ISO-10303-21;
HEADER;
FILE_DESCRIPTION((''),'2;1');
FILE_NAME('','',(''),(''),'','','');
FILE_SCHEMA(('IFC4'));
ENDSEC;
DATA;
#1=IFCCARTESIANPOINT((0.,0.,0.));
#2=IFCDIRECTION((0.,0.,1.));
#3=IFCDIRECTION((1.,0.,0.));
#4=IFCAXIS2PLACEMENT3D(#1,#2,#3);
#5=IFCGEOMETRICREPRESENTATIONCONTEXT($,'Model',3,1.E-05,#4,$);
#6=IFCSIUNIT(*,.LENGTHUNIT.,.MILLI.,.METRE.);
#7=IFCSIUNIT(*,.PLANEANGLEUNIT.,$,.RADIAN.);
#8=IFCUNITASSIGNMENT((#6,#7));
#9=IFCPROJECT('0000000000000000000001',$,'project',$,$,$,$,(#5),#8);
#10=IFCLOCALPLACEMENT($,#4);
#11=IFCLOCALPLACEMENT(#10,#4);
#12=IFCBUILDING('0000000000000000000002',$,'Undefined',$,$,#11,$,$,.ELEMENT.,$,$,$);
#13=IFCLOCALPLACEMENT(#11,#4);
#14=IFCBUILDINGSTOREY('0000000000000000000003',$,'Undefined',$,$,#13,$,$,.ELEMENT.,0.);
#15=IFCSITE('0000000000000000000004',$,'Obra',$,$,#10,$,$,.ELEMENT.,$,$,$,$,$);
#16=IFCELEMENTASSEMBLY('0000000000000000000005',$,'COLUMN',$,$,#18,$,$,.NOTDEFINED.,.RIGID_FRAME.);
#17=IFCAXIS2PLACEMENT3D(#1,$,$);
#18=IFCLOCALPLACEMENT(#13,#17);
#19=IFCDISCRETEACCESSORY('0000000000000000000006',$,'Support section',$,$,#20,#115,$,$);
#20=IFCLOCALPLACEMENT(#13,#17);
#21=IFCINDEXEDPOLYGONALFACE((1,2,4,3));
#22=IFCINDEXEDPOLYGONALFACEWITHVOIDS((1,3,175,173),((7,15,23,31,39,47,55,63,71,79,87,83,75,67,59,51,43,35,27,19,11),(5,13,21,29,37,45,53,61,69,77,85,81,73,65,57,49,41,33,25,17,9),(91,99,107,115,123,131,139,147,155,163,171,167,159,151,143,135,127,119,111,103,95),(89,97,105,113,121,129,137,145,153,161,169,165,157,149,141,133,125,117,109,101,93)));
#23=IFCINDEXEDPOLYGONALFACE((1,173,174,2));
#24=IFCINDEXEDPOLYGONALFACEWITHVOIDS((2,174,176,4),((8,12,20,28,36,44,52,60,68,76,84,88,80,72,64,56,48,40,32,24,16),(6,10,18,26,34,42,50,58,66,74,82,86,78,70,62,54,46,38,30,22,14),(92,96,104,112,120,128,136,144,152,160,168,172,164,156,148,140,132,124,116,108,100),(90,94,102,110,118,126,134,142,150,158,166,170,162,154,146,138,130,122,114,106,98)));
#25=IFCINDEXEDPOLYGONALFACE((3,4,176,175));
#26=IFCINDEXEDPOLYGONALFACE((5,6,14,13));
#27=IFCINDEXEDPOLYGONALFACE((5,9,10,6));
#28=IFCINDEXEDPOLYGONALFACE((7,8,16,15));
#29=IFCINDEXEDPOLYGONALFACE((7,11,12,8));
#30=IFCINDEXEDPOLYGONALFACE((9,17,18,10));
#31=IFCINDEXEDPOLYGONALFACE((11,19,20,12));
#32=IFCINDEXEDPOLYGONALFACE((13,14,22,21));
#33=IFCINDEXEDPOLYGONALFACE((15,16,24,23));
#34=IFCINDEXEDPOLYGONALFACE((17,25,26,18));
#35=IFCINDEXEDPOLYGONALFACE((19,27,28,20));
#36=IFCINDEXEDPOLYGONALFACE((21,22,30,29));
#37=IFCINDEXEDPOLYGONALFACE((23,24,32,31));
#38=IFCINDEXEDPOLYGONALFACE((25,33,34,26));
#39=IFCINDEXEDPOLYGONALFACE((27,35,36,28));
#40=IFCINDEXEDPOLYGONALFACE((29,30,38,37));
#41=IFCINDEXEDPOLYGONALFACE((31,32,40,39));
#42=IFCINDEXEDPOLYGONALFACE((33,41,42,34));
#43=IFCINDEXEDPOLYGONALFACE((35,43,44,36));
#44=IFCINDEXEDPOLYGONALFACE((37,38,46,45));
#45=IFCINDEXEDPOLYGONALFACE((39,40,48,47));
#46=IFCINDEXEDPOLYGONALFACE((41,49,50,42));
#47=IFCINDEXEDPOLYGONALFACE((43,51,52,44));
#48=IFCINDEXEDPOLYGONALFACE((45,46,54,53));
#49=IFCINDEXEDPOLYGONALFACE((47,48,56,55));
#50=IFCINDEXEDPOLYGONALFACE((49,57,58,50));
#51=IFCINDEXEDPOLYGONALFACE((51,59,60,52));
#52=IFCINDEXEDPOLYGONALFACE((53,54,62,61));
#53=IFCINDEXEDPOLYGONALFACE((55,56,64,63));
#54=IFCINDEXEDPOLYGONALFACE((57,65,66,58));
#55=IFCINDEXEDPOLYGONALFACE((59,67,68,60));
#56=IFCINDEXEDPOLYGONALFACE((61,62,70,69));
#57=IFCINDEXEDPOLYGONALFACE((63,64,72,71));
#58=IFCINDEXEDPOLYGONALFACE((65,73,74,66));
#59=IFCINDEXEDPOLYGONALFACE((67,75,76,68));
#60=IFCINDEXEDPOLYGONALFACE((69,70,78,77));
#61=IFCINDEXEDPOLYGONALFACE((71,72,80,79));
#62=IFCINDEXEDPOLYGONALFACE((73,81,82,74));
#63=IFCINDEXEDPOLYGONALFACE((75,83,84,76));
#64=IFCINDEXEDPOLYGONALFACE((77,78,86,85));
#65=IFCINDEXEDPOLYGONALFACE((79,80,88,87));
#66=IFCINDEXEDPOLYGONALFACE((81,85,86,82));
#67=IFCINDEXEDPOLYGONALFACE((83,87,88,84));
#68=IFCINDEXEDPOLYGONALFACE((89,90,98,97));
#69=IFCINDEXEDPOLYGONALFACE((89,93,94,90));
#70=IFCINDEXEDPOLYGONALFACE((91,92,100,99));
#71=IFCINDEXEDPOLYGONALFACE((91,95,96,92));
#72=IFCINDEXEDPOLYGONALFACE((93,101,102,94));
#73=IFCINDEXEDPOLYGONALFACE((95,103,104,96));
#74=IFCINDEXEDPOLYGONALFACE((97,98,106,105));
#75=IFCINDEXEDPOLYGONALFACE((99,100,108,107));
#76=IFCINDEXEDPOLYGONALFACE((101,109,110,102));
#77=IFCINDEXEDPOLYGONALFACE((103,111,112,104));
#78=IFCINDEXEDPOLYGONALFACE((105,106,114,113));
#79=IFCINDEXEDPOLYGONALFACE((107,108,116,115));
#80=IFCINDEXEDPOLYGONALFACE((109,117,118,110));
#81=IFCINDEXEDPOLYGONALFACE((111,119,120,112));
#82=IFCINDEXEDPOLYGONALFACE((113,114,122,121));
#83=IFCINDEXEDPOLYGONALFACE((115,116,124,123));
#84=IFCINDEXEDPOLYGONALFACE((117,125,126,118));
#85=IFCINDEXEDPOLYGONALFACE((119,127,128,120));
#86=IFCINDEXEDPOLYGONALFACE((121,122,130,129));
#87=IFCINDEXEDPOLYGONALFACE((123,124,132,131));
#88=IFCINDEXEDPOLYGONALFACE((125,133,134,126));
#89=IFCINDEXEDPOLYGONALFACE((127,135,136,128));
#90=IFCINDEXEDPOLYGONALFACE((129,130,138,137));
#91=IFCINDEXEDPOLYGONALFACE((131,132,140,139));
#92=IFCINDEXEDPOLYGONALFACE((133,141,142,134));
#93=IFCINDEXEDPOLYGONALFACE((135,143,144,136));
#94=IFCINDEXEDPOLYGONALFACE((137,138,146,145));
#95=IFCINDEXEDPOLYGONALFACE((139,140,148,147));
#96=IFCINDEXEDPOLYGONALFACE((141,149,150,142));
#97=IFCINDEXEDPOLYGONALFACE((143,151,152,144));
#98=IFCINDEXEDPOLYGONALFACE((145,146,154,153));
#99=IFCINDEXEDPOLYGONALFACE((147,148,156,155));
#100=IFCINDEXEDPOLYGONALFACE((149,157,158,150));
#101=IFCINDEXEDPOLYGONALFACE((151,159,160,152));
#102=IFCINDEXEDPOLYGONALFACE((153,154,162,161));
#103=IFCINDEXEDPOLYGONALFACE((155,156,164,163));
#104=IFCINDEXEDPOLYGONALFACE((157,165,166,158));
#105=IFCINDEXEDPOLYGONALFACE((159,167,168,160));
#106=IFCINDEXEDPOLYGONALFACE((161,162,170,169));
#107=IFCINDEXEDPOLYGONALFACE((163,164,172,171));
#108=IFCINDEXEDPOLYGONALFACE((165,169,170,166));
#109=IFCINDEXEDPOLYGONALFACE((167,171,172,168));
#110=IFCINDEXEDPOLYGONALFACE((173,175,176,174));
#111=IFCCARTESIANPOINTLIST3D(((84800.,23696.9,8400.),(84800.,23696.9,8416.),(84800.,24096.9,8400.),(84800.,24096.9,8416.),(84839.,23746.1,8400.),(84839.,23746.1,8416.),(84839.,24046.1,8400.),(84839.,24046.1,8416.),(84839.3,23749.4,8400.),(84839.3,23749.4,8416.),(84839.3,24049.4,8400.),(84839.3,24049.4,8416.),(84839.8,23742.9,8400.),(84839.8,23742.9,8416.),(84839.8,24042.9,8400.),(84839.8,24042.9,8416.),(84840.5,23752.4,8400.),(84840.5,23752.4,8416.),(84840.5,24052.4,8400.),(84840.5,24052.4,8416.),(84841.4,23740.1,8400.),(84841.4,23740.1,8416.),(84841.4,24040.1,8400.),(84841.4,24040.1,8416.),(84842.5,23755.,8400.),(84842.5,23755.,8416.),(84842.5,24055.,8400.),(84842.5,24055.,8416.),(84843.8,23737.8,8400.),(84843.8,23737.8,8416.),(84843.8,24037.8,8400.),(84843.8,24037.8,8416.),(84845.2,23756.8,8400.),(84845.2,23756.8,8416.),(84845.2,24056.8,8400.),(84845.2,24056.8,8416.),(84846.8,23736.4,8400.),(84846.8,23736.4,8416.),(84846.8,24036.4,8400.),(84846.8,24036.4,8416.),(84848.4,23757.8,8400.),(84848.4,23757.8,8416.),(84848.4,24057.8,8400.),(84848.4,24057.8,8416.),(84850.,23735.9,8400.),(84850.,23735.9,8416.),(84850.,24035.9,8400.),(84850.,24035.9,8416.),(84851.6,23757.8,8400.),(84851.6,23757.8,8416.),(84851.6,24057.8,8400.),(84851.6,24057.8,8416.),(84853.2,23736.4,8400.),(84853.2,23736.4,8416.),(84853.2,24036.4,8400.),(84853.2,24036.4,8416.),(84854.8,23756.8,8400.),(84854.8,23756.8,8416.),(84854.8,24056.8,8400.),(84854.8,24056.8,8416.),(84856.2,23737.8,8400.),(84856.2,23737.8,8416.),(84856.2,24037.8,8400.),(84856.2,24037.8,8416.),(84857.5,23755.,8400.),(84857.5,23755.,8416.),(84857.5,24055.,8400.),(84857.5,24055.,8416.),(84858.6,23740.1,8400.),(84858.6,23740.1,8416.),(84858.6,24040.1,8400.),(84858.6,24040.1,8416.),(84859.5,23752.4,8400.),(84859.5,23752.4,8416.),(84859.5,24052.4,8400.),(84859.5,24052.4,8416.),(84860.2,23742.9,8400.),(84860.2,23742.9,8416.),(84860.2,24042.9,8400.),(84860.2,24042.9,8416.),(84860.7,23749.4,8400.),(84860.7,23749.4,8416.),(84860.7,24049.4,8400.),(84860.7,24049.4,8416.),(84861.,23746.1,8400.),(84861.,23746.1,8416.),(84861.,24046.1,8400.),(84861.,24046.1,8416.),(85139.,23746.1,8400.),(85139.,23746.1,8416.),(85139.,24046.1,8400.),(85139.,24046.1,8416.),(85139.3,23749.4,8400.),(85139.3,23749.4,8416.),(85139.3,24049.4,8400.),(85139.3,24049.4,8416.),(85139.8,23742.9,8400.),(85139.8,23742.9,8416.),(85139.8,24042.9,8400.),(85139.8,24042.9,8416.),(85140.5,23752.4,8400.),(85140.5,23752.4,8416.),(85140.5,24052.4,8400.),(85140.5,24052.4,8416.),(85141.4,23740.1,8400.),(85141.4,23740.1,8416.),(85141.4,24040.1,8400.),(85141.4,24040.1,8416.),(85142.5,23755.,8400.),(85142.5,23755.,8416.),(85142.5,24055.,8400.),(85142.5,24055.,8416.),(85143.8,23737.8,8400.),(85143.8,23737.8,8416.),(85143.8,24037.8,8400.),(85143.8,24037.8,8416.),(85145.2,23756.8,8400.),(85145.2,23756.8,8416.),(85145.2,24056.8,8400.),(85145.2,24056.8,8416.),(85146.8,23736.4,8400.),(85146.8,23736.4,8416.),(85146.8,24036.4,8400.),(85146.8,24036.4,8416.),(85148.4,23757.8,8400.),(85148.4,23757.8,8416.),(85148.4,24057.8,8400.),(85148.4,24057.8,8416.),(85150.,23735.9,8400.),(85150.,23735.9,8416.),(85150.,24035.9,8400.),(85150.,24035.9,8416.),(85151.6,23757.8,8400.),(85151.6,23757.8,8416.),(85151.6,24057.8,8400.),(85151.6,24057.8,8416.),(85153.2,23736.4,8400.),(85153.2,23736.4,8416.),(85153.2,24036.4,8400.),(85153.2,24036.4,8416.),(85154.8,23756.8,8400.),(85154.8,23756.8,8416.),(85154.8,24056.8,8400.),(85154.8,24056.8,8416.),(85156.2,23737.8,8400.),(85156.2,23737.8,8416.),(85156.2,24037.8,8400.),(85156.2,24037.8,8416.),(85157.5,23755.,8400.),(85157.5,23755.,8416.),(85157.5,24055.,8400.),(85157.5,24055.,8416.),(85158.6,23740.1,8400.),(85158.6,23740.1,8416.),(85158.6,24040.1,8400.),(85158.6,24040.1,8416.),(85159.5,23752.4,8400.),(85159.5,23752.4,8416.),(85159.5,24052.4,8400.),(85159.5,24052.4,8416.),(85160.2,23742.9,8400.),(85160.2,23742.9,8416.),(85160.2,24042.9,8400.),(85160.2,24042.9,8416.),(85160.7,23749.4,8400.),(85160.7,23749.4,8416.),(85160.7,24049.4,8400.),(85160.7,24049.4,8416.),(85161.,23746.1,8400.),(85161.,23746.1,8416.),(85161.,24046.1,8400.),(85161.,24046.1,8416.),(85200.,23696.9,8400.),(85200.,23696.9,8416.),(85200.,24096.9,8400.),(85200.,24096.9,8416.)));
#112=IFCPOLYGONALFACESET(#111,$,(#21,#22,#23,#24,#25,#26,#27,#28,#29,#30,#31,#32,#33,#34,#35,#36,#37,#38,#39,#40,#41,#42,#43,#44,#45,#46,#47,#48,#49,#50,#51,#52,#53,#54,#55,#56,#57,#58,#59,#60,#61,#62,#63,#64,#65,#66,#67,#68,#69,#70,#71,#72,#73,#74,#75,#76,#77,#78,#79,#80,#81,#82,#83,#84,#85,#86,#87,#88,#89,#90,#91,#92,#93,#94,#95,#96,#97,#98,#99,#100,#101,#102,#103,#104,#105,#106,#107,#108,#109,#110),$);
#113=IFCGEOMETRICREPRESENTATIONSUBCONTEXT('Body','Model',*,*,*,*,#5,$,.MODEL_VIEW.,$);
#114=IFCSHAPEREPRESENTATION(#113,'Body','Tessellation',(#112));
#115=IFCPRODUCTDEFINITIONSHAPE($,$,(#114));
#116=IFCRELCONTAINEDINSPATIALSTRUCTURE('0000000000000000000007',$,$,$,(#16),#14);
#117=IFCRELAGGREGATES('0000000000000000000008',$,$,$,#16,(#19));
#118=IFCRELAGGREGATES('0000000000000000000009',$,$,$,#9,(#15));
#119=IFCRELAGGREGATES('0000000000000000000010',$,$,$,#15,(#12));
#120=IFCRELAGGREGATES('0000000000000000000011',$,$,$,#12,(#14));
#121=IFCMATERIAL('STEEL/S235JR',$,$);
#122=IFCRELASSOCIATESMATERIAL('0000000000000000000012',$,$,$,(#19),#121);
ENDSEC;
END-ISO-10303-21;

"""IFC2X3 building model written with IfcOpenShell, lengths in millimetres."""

from ifc_helpers import new_model, si_unit, frame, origin_with_axes, origin_2d_with_axis, place, context, subcontext, project, spatial, rectangle, circle, extrude, source, transform, mapped, material, element, aggregate, save


model = new_model("IFC2X3")

# Units and contexts
model_context = context("Model", 3, precision=1e-05, world=origin_with_axes())
body_context = subcontext(model_context, "Body", "Model", "MODEL_VIEW")
ifc_project = project(units=[si_unit("LENGTHUNIT", "METRE", prefix="MILLI"), si_unit("PLANEANGLEUNIT", "RADIAN")], contexts=[model_context])

# Site, building, storey
site_placement = place(None, origin_with_axes())
site = spatial("IfcSite", under=ifc_project, at=site_placement, Name="Obra", CompositionType="ELEMENT")
building_placement = place(site_placement, origin_with_axes())
building = spatial("IfcBuilding", under=site, at=building_placement, Name="Undefined", CompositionType="ELEMENT")
storey_placement = place(building_placement, origin_with_axes())
storey = spatial("IfcBuildingStorey", under=building, at=storey_placement, Name="Undefined", CompositionType="ELEMENT", Elevation=0.0)

# Shared definitions
ifc_material_1 = material(Name="STEEL/S235JR")

# Shared definitions
shared_shape_1 = source(origin_with_axes(), body_context, "Body", "SweptSolid", [
    extrude(circle(Radius=11.0, at=origin_2d_with_axis()), frame((0.0, -0.1, 0.0), z_axis=(0.0, 1.0, 0.0), x_axis=(1.0, 0.0, 0.0)), (0.0, 0.0, 1.0), 16.2),
])

# Element assembly
assembly_1_placement = place(storey_placement, origin_with_axes())
assembly_1 = element("IfcElementAssembly", 1, at=assembly_1_placement, inside=storey, Name="COLUMN", AssemblyPlace="NOTDEFINED", PredefinedType="RIGID_FRAME")

# Discrete accessory, opening
discrete_accessory_1_placement = place(assembly_1_placement, frame((85000.0, 23696.9, 8408.0), z_axis=(-1.0, 0.0, 0.0), x_axis=(0.0, 1.0, 0.0)))
discrete_accessory_1 = element("IfcDiscreteAccessory", 2, at=discrete_accessory_1_placement, material=ifc_material_1, Name="Support section", context=body_context, shape_type="SweptSolid", body=[
    extrude(rectangle(XDim=16.0, YDim=400.0, at=origin_2d_with_axis()), frame((400.0, 0.0, 0.0), z_axis=(-1.0, 0.0, 0.0), x_axis=(0.0, -1.0, 0.0)), (0.0, 0.0, 1.0), 400.0),
])
opening_1_placement = place(assembly_1_placement, frame((85000.0, 24049.4, 8416.0), z_axis=(1.0, 0.0, 0.0), x_axis=(0.0, -1.0, 0.0)))
element("IfcOpeningElement", 3, at=opening_1_placement, cuts=discrete_accessory_1, ObjectType="Opening", context=body_context, shape_type="MappedRepresentation", body=[
    mapped(shared_shape_1, transform((2.5, 0.0, 150.0))),
    mapped(shared_shape_1, transform((2.5, 0.0, -150.0))),
    mapped(shared_shape_1, transform((302.5, 0.0, 150.0))),
    mapped(shared_shape_1, transform((302.5, 0.0, -150.0))),
])
aggregate(assembly_1, [discrete_accessory_1])

save(model, "model.ifc")
